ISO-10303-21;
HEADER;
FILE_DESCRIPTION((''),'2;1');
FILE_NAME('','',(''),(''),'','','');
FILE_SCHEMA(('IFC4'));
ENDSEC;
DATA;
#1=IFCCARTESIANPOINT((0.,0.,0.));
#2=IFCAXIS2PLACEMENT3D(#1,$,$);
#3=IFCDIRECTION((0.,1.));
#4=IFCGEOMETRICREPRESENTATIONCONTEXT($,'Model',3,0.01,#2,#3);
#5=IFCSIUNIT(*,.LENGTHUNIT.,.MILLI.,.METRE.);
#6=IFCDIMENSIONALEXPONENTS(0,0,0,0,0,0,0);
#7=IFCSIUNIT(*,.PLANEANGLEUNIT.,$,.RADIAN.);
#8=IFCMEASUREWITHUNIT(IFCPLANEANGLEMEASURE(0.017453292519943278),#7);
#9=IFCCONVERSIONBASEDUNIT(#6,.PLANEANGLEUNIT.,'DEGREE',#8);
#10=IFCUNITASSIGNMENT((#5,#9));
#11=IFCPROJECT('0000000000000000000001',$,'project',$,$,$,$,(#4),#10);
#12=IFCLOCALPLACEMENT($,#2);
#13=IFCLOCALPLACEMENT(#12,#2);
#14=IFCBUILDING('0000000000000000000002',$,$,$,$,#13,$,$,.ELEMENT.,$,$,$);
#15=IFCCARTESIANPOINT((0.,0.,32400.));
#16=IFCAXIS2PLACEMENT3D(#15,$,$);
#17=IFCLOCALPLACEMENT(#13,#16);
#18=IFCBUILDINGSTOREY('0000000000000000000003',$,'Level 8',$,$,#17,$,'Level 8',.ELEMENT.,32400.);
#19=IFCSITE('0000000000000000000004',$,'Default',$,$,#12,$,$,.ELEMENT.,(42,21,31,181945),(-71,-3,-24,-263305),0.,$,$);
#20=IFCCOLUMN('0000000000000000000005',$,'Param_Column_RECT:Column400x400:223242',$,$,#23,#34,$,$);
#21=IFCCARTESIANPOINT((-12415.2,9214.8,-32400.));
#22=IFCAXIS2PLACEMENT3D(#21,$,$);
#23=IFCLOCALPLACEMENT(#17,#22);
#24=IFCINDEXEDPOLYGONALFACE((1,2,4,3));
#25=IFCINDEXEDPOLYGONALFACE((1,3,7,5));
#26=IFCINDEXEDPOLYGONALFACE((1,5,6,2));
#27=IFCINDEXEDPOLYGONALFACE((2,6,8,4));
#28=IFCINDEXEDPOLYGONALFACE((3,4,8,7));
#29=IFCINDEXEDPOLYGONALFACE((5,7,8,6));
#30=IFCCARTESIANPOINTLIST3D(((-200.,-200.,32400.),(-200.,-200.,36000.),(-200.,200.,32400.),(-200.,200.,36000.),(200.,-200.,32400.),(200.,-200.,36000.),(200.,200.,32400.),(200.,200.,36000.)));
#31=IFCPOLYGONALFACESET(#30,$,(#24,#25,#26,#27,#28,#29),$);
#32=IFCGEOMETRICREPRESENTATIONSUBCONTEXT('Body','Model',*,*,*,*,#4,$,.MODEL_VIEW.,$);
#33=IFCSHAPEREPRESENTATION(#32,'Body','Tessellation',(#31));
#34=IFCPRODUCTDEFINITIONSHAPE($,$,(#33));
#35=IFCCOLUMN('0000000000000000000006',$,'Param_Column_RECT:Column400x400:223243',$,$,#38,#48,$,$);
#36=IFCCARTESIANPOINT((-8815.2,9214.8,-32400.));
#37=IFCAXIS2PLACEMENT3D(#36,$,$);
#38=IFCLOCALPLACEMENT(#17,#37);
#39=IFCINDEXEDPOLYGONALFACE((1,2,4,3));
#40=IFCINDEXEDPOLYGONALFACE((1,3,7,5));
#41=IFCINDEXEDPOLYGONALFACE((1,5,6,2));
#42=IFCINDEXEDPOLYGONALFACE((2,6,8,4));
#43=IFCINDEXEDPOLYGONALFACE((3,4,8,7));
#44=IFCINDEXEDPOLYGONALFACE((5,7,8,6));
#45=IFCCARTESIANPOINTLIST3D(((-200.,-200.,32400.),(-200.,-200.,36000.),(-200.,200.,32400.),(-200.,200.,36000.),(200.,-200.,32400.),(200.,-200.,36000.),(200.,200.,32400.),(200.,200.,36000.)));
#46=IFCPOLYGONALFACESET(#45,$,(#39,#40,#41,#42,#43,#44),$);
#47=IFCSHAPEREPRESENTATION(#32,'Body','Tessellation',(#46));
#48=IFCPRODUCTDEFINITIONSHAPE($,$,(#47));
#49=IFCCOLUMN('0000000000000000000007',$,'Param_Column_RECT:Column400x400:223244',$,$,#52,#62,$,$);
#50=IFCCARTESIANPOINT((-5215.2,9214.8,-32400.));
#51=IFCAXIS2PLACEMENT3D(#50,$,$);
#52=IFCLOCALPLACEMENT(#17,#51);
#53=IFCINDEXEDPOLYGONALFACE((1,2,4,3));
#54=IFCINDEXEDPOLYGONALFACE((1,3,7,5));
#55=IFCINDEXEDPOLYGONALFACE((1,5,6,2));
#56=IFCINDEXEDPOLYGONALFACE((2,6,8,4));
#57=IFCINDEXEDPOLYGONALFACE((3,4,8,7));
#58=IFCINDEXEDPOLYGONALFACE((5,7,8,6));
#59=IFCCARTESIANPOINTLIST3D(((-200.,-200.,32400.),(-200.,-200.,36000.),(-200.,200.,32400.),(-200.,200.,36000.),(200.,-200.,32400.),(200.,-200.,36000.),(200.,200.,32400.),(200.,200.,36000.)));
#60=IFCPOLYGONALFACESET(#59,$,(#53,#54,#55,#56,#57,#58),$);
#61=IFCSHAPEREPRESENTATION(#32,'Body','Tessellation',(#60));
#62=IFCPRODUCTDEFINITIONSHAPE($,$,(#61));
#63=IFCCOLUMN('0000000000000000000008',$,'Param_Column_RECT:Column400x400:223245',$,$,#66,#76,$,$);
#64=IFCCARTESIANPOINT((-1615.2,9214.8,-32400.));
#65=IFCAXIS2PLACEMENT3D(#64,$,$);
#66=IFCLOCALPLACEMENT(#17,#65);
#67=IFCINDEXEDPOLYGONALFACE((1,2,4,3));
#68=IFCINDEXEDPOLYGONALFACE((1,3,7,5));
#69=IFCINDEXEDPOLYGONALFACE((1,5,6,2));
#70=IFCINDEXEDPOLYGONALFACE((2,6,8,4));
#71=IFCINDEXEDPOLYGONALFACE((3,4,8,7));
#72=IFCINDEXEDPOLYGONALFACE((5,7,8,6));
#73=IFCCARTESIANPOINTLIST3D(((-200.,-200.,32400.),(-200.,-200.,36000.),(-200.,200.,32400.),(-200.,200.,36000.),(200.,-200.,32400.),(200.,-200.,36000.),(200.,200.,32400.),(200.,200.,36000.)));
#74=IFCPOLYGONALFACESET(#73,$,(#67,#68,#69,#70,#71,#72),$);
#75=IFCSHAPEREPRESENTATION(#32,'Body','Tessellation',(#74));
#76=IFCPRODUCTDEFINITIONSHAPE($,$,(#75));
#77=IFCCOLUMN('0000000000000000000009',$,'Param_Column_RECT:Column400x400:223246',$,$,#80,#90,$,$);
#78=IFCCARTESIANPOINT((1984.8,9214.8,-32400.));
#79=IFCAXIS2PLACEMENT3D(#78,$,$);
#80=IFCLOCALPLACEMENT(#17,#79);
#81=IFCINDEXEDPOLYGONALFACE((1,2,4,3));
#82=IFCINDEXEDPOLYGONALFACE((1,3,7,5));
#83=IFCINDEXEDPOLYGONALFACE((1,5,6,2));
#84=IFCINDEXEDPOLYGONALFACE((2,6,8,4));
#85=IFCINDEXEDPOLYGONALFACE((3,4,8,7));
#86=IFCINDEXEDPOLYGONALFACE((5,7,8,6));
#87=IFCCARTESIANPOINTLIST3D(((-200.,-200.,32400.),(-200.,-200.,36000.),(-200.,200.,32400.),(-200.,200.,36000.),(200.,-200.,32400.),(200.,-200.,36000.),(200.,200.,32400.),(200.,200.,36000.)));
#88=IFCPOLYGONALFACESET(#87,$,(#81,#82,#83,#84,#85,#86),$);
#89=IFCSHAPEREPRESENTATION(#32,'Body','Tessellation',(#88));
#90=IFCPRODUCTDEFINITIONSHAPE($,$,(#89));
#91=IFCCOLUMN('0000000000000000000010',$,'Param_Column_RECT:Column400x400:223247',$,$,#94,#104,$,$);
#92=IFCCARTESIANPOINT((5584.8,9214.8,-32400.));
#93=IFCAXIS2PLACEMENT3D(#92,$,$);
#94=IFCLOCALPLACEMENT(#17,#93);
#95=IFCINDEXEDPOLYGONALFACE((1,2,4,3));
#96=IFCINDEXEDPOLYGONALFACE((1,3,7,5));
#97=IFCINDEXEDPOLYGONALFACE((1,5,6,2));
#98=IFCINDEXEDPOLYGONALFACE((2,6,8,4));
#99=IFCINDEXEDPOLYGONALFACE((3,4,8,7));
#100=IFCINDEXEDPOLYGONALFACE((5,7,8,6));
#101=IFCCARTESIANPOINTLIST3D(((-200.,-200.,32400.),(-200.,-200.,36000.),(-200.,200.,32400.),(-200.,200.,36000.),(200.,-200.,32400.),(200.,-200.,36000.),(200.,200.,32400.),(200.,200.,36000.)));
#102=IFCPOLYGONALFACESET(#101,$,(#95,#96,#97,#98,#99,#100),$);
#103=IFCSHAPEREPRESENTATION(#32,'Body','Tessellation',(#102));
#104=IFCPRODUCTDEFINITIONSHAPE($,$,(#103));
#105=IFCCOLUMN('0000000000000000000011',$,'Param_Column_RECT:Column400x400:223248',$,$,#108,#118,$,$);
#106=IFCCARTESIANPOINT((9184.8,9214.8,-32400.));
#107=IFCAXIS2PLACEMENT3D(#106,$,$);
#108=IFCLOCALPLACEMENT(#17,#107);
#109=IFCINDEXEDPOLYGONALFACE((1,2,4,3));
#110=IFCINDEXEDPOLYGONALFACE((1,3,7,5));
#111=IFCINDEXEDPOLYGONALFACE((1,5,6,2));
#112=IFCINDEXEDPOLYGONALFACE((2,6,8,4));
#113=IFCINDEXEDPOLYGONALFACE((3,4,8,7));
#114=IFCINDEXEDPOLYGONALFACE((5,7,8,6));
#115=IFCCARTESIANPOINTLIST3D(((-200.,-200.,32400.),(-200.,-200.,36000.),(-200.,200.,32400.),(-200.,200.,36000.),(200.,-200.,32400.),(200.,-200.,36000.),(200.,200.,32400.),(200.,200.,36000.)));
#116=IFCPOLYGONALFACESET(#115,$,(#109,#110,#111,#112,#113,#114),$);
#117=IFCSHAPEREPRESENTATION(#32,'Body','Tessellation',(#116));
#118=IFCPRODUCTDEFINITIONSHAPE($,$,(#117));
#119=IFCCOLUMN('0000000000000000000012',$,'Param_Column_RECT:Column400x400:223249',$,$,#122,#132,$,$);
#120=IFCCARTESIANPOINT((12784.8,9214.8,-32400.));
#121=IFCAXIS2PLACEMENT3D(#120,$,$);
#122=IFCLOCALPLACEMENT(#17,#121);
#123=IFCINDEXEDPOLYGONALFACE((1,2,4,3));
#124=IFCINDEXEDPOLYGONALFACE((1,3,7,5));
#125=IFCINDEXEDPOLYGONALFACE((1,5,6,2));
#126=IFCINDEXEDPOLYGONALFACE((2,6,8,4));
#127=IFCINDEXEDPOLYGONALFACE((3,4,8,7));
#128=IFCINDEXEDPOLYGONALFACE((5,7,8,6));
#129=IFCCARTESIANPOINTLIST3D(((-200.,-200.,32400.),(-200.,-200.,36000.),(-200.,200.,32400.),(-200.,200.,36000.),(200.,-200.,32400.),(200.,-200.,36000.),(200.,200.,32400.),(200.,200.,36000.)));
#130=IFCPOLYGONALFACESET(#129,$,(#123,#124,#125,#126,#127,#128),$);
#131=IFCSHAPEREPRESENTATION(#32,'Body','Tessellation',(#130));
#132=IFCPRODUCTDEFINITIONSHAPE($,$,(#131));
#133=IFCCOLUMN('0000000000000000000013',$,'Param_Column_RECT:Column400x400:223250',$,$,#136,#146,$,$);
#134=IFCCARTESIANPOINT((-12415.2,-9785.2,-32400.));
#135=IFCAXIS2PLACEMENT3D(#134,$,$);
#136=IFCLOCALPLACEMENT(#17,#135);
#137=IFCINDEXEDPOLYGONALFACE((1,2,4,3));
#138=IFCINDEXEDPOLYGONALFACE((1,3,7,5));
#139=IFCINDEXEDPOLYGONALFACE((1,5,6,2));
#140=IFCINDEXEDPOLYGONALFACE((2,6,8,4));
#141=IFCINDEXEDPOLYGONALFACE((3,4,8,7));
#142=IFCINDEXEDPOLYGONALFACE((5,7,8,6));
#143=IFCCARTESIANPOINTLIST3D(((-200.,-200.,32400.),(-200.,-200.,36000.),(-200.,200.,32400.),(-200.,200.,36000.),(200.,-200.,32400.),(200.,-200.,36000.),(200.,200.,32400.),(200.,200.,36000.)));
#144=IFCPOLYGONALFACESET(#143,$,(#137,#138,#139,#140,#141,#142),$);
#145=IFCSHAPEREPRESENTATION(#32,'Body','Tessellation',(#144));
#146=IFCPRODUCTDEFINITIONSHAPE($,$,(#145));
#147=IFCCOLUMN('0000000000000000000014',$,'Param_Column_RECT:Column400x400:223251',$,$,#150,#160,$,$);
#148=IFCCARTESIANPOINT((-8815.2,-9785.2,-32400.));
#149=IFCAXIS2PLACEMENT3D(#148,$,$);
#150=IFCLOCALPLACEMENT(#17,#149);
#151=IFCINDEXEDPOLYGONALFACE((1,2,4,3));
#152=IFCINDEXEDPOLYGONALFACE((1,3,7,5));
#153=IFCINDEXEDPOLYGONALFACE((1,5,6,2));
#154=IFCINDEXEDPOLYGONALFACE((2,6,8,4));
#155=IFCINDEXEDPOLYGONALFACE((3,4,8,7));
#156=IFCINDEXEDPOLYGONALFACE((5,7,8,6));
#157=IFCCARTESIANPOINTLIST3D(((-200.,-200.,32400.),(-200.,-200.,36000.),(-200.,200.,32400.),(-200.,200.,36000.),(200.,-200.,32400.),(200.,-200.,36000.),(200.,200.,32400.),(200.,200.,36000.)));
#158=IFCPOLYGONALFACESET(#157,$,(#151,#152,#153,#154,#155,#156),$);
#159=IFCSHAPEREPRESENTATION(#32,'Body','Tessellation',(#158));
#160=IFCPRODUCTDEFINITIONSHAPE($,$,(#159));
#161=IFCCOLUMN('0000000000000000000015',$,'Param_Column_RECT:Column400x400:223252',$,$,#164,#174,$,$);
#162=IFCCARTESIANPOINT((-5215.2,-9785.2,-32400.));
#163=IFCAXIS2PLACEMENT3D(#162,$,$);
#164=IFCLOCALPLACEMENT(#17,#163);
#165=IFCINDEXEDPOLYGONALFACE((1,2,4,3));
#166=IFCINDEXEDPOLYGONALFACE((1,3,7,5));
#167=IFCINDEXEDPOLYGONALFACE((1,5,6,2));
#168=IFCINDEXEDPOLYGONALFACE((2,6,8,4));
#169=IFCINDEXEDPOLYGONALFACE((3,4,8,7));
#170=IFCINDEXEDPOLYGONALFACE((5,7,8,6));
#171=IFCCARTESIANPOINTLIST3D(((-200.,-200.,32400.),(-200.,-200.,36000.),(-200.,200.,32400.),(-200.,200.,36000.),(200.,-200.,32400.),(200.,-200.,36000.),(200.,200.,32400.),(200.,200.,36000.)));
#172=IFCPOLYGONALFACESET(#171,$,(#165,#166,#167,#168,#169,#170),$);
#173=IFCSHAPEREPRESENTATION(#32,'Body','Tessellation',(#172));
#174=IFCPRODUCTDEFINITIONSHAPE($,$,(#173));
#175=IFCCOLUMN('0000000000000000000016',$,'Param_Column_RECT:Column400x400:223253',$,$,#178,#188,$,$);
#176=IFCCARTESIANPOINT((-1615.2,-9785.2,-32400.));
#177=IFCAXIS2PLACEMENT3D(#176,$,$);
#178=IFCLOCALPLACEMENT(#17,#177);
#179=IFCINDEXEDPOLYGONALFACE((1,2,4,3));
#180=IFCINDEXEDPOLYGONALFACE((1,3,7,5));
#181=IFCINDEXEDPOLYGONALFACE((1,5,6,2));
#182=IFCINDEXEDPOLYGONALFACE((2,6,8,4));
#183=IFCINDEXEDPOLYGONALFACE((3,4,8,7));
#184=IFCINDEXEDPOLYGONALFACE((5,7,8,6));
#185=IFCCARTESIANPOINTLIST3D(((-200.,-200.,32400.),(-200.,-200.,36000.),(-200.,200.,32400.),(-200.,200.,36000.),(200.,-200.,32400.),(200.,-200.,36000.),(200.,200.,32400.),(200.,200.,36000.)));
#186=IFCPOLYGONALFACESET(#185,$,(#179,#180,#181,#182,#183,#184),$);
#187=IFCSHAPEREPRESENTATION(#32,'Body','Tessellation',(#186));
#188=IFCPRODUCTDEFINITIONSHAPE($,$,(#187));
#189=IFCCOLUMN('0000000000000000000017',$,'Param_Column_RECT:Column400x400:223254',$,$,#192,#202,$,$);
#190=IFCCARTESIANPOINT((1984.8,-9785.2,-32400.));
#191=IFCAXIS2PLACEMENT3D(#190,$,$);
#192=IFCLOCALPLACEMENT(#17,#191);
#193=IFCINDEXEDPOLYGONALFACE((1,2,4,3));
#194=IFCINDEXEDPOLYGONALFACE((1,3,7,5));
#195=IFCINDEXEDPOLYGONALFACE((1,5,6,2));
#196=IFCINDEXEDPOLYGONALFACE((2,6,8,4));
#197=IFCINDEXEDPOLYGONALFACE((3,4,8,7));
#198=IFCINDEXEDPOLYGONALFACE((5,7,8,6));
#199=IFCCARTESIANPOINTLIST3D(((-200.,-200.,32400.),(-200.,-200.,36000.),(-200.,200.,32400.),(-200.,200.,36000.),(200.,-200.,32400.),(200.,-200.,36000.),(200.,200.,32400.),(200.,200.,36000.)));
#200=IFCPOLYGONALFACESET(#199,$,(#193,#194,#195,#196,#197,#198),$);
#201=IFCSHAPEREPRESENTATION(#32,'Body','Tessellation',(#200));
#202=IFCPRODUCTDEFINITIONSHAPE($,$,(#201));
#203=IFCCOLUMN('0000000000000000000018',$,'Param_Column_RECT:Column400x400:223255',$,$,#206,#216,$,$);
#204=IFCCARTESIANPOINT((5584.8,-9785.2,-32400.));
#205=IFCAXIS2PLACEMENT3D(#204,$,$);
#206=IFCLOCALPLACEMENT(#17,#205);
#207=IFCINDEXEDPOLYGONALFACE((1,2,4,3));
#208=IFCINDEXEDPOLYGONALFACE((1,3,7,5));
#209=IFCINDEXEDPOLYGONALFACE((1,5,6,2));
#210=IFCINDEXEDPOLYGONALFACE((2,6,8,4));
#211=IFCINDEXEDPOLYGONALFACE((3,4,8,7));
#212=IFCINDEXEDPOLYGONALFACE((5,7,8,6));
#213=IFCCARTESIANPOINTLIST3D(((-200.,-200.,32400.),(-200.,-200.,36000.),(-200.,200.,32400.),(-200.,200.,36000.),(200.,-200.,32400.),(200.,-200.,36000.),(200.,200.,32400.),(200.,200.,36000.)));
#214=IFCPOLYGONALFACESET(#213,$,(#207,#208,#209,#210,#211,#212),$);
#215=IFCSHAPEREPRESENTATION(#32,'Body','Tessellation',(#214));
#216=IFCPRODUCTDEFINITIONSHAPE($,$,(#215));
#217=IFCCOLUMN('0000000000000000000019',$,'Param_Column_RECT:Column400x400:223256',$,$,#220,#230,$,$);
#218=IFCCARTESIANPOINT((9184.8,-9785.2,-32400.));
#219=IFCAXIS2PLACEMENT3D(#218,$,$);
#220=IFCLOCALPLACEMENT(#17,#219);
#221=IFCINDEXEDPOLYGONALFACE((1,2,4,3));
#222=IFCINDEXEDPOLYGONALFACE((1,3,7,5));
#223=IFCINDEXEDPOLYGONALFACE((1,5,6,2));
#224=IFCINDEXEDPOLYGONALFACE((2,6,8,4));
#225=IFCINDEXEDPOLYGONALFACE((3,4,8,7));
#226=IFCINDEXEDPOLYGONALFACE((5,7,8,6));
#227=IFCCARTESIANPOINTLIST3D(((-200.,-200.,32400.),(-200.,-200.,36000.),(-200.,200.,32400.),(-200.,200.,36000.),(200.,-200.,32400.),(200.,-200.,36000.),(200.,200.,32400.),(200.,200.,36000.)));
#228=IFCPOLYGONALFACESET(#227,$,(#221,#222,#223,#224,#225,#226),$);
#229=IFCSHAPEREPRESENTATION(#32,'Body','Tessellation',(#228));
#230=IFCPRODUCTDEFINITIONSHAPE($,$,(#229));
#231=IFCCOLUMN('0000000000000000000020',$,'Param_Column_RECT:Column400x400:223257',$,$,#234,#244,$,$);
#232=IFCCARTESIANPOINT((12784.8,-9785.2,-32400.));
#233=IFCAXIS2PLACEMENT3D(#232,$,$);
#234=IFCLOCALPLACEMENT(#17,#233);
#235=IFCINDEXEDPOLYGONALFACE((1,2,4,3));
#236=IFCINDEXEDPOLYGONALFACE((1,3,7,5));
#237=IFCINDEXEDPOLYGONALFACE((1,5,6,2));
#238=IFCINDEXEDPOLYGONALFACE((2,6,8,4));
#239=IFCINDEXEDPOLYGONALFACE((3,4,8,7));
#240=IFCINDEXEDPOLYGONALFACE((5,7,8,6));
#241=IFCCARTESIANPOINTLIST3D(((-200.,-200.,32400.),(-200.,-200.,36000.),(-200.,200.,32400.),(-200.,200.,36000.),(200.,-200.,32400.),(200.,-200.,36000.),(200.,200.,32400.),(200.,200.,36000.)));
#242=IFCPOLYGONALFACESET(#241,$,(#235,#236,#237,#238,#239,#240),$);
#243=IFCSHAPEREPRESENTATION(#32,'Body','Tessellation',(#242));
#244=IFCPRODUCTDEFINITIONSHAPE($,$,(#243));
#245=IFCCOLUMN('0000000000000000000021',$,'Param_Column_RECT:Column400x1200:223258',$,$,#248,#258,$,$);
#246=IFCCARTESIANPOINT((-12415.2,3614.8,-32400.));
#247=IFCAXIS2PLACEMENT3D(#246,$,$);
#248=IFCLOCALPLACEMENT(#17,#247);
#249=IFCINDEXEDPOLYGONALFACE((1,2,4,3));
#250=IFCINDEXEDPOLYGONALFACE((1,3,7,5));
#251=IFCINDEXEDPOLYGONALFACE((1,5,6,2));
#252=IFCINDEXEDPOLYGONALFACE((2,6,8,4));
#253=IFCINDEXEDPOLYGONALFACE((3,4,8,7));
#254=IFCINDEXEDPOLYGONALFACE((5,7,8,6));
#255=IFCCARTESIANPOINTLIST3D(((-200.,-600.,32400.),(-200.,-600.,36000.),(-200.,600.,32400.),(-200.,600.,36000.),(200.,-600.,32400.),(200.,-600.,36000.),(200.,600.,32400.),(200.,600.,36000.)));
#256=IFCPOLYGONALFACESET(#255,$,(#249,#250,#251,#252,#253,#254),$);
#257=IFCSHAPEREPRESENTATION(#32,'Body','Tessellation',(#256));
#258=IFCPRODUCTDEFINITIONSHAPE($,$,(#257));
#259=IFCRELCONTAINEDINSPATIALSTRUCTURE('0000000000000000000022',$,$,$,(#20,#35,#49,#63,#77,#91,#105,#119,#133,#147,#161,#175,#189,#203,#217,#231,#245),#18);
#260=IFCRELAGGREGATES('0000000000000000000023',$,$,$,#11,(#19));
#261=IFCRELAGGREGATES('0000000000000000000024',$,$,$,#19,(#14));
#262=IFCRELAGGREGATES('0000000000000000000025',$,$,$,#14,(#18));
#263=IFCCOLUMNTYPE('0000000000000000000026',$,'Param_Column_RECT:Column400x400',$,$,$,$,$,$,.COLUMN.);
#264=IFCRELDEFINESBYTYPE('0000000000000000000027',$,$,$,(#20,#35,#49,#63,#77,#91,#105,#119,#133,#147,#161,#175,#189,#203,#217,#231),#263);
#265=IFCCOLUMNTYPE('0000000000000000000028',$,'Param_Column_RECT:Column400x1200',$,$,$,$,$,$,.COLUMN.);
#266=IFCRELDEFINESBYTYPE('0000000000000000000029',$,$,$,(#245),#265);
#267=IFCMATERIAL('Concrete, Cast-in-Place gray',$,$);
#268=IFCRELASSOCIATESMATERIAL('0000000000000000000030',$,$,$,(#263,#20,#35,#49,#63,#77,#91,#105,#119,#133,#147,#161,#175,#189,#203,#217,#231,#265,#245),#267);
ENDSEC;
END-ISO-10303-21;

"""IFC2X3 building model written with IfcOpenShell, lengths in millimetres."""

from ifc_helpers import new_model, entity, si_unit, converted_unit, direction, frame, origin, origin_2d_with_axis, place, context, subcontext, project, spatial, rectangle, extrude, source, transform, mapped, material, type_object, type_shapes, element, save


model = new_model("IFC2X3")

# Units and contexts
model_context = context("Model", 3, precision=0.01, world=origin(), true_north=direction((0.0, 1.0)))
body_context = subcontext(model_context, "Body", "Model", "MODEL_VIEW")
ifc_project = project(units=[si_unit("LENGTHUNIT", "METRE", prefix="MILLI"), converted_unit("PLANEANGLEUNIT", "DEGREE", entity("IfcPlaneAngleMeasure", 0.017453292519943278), si_unit("PLANEANGLEUNIT", "RADIAN"), dimensions=[0, 0, 0, 0, 0, 0, 0])], contexts=[model_context])

# Site, building, storey
site_placement = place(None, origin())
site = spatial("IfcSite", under=ifc_project, at=site_placement, Name="Default", CompositionType="ELEMENT", RefLatitude=(42, 21, 31, 181945), RefLongitude=(-71, -3, -24, -263305), RefElevation=0.0)
building_placement = place(site_placement, origin())
building = spatial("IfcBuilding", under=site, at=building_placement, CompositionType="ELEMENT")
storey_placement = place(building_placement, frame((0.0, 0.0, 32400.0)))
storey = spatial("IfcBuildingStorey", under=building, at=storey_placement, Name="Level 8", LongName="Level 8", CompositionType="ELEMENT", Elevation=32400.0)

# Columns
ifc_material_1 = material(Name="Concrete, Cast-in-Place gray")
column_type_1 = type_object("IfcColumnType", Name="Param_Column_RECT:Column400x400", PredefinedType="COLUMN", material=ifc_material_1)
shared_shape_1 = source(origin(), body_context, "Body", "SweptSolid", [
    extrude(rectangle(XDim=400.0, YDim=400.0, at=origin_2d_with_axis()), frame((0.0, 0.0, 32400.0), z_axis=(0.0, 0.0, 1.0), x_axis=(-1.0, 0.0, 0.0)), (0.0, 0.0, 1.0), 3600.0),
])
type_shapes(column_type_1, [shared_shape_1])
for number, where, name in (
    (1, (-12415.2, 9214.8, -32400.0), "Param_Column_RECT:Column400x400:223242"),
    (2, (-8815.2, 9214.8, -32400.0), "Param_Column_RECT:Column400x400:223243"),
    (3, (-5215.2, 9214.8, -32400.0), "Param_Column_RECT:Column400x400:223244"),
    (4, (-1615.2, 9214.8, -32400.0), "Param_Column_RECT:Column400x400:223245"),
    (5, (1984.8, 9214.8, -32400.0), "Param_Column_RECT:Column400x400:223246"),
    (6, (5584.8, 9214.8, -32400.0), "Param_Column_RECT:Column400x400:223247"),
    (7, (9184.8, 9214.8, -32400.0), "Param_Column_RECT:Column400x400:223248"),
    (8, (12784.8, 9214.8, -32400.0), "Param_Column_RECT:Column400x400:223249"),
    (9, (-12415.2, -9785.2, -32400.0), "Param_Column_RECT:Column400x400:223250"),
    (10, (-8815.2, -9785.2, -32400.0), "Param_Column_RECT:Column400x400:223251"),
    (11, (-5215.2, -9785.2, -32400.0), "Param_Column_RECT:Column400x400:223252"),
    (12, (-1615.2, -9785.2, -32400.0), "Param_Column_RECT:Column400x400:223253"),
    (13, (1984.8, -9785.2, -32400.0), "Param_Column_RECT:Column400x400:223254"),
    (14, (5584.8, -9785.2, -32400.0), "Param_Column_RECT:Column400x400:223255"),
    (15, (9184.8, -9785.2, -32400.0), "Param_Column_RECT:Column400x400:223256"),
    (16, (12784.8, -9785.2, -32400.0), "Param_Column_RECT:Column400x400:223257"),
):
    element("IfcColumn", number, at=place(storey_placement, frame(where)), inside=storey, type_object=column_type_1, material=ifc_material_1, Name=name, context=body_context, shape_type="MappedRepresentation", body=[
        mapped(shared_shape_1, transform((0.0, 0.0, 0.0), scale=1.0)),
    ])
column_type_2 = type_object("IfcColumnType", Name="Param_Column_RECT:Column400x1200", PredefinedType="COLUMN", material=ifc_material_1)
shared_shape_2 = source(origin(), body_context, "Body", "SweptSolid", [
    extrude(rectangle(XDim=400.0, YDim=1200.0, at=origin_2d_with_axis()), frame((0.0, 0.0, 32400.0), z_axis=(0.0, 0.0, 1.0), x_axis=(-1.0, 0.0, 0.0)), (0.0, 0.0, 1.0), 3600.0),
])
type_shapes(column_type_2, [shared_shape_2])
for number, where, name in (
    (17, (-12415.2, 3614.8, -32400.0), "Param_Column_RECT:Column400x1200:223258"),
):
    element("IfcColumn", number, at=place(storey_placement, frame(where)), inside=storey, type_object=column_type_2, material=ifc_material_1, Name=name, context=body_context, shape_type="MappedRepresentation", body=[
        mapped(shared_shape_2, transform((0.0, 0.0, 0.0), scale=1.0)),
    ])

save(model, "model.ifc")
